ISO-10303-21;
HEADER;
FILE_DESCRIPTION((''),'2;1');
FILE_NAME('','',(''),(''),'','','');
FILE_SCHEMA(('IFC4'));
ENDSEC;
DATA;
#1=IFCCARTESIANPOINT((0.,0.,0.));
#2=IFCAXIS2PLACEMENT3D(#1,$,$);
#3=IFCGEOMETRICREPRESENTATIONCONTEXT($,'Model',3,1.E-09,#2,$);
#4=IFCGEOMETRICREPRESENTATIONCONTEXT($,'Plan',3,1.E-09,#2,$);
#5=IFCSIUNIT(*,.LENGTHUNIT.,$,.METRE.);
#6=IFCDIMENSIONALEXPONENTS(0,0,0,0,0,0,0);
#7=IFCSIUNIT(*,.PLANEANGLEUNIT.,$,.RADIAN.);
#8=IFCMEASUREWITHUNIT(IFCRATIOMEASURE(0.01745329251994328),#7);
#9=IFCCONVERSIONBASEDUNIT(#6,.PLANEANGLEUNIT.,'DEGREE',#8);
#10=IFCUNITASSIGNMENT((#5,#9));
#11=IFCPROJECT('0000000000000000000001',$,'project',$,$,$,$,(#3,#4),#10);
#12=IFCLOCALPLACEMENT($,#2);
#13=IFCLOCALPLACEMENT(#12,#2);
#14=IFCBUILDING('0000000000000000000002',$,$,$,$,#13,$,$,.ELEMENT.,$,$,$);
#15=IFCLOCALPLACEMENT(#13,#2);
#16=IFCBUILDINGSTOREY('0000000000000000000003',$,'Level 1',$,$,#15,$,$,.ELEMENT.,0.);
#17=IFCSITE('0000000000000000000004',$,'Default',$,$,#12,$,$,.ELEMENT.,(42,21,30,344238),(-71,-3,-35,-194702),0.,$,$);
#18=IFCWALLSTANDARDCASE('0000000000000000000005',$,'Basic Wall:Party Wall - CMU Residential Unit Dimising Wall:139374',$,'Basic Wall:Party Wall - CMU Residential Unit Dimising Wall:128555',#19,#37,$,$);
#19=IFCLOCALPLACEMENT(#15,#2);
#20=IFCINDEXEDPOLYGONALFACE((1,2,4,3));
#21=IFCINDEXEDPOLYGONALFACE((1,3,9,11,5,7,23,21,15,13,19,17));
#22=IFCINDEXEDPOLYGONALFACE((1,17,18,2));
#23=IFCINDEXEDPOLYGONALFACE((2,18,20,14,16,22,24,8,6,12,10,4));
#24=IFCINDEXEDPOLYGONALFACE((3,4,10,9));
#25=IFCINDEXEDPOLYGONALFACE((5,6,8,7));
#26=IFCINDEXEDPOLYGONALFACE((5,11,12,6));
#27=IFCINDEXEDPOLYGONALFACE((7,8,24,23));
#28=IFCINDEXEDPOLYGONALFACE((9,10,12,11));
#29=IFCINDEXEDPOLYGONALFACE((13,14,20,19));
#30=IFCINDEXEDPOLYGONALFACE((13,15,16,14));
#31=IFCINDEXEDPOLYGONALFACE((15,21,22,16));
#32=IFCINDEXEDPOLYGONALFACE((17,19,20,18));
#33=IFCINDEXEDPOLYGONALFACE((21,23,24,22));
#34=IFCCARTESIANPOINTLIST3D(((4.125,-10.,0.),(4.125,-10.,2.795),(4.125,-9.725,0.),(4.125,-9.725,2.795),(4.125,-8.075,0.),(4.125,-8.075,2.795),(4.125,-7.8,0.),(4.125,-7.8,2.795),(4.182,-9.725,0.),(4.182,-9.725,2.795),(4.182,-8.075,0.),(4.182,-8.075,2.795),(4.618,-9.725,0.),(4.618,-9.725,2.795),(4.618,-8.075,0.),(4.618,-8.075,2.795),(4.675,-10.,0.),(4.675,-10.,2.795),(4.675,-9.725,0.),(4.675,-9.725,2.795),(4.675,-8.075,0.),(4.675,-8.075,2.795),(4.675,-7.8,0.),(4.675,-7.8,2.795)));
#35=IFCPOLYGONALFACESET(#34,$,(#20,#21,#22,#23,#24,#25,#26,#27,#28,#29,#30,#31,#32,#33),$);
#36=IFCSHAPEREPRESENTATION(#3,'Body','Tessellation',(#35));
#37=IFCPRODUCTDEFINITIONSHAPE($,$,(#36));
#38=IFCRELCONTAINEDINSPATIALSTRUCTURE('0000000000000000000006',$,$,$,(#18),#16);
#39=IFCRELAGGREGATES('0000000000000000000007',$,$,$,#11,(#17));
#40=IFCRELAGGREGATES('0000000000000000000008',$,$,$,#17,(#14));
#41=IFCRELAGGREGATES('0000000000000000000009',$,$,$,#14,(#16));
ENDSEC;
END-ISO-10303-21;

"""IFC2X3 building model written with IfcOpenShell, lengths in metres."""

from ifc_helpers import new_model, entity, si_unit, converted_unit, frame, frame_2d, origin, place, context, project, spatial, polyline, rectangle, extrude, clip, bounded_halfspace, element, save


model = new_model("IFC2X3")

# Units and contexts
model_context = context("Model", 3, precision=1e-09, world=origin())
plan_context = context("Plan", 3, precision=1e-09, world=origin())
ifc_project = project(units=[si_unit("LENGTHUNIT", "METRE"), converted_unit("PLANEANGLEUNIT", "DEGREE", entity("IfcRatioMeasure", 0.01745329251994328), si_unit("PLANEANGLEUNIT", "RADIAN"), dimensions=[0, 0, 0, 0, 0, 0, 0])], contexts=[model_context, plan_context])

# Site, building, storey
site_placement = place(None, origin())
site = spatial("IfcSite", under=ifc_project, at=site_placement, Name="Default", CompositionType="ELEMENT", RefLatitude=(42, 21, 30, 344238), RefLongitude=(-71, -3, -35, -194702), RefElevation=0.0)
building_placement = place(site_placement, origin())
building = spatial("IfcBuilding", under=site, at=building_placement, CompositionType="ELEMENT")
storey_placement = place(building_placement, origin())
storey = spatial("IfcBuildingStorey", under=building, at=storey_placement, Name="Level 1", CompositionType="ELEMENT", Elevation=0.0)

# Wall
wall_1_placement = place(storey_placement, frame((4.4, -10.0, 0.0), z_axis=(0.0, 0.0, 1.0), x_axis=(0.0, 1.0, 0.0)))
element("IfcWallStandardCase", 1, at=wall_1_placement, inside=storey, Name="Basic Wall:Party Wall - CMU Residential Unit Dimising Wall:139374", ObjectType="Basic Wall:Party Wall - CMU Residential Unit Dimising Wall:128555", context=model_context, shape_type="Clipping", body=[
    clip(clip(extrude(rectangle(XDim=2.2, YDim=0.55, at=frame_2d((1.1, 0.0), x_axis=(-1.0, 0.0))), origin(), (0.0, 0.0, 1.0), 2.795), bounded_halfspace(frame((1.925, 0.218, 0.0), z_axis=(0.0, -1.0, 0.0), x_axis=(1.0, 0.0, 0.0)), True, frame((1.925, 0.218, 0.0), z_axis=(0.0, -1.0, 0.0), x_axis=(1.0, 0.0, 0.0)), polyline([(0.0, 0.0), (0.0, 2.795), (-1.65, 2.795), (-1.65, 0.0), (0.0, 0.0)]))), bounded_halfspace(frame((0.275, -0.218, 0.0), z_axis=(0.0, 1.0, 0.0), x_axis=(-1.0, 0.0, 0.0)), True, frame((0.275, -0.218, 0.0), z_axis=(0.0, 1.0, 0.0), x_axis=(-1.0, 0.0, 0.0)), polyline([(0.0, 0.0), (0.0, 2.795), (-1.65, 2.795), (-1.65, 0.0), (0.0, 0.0)]))),
])

save(model, "model.ifc")
